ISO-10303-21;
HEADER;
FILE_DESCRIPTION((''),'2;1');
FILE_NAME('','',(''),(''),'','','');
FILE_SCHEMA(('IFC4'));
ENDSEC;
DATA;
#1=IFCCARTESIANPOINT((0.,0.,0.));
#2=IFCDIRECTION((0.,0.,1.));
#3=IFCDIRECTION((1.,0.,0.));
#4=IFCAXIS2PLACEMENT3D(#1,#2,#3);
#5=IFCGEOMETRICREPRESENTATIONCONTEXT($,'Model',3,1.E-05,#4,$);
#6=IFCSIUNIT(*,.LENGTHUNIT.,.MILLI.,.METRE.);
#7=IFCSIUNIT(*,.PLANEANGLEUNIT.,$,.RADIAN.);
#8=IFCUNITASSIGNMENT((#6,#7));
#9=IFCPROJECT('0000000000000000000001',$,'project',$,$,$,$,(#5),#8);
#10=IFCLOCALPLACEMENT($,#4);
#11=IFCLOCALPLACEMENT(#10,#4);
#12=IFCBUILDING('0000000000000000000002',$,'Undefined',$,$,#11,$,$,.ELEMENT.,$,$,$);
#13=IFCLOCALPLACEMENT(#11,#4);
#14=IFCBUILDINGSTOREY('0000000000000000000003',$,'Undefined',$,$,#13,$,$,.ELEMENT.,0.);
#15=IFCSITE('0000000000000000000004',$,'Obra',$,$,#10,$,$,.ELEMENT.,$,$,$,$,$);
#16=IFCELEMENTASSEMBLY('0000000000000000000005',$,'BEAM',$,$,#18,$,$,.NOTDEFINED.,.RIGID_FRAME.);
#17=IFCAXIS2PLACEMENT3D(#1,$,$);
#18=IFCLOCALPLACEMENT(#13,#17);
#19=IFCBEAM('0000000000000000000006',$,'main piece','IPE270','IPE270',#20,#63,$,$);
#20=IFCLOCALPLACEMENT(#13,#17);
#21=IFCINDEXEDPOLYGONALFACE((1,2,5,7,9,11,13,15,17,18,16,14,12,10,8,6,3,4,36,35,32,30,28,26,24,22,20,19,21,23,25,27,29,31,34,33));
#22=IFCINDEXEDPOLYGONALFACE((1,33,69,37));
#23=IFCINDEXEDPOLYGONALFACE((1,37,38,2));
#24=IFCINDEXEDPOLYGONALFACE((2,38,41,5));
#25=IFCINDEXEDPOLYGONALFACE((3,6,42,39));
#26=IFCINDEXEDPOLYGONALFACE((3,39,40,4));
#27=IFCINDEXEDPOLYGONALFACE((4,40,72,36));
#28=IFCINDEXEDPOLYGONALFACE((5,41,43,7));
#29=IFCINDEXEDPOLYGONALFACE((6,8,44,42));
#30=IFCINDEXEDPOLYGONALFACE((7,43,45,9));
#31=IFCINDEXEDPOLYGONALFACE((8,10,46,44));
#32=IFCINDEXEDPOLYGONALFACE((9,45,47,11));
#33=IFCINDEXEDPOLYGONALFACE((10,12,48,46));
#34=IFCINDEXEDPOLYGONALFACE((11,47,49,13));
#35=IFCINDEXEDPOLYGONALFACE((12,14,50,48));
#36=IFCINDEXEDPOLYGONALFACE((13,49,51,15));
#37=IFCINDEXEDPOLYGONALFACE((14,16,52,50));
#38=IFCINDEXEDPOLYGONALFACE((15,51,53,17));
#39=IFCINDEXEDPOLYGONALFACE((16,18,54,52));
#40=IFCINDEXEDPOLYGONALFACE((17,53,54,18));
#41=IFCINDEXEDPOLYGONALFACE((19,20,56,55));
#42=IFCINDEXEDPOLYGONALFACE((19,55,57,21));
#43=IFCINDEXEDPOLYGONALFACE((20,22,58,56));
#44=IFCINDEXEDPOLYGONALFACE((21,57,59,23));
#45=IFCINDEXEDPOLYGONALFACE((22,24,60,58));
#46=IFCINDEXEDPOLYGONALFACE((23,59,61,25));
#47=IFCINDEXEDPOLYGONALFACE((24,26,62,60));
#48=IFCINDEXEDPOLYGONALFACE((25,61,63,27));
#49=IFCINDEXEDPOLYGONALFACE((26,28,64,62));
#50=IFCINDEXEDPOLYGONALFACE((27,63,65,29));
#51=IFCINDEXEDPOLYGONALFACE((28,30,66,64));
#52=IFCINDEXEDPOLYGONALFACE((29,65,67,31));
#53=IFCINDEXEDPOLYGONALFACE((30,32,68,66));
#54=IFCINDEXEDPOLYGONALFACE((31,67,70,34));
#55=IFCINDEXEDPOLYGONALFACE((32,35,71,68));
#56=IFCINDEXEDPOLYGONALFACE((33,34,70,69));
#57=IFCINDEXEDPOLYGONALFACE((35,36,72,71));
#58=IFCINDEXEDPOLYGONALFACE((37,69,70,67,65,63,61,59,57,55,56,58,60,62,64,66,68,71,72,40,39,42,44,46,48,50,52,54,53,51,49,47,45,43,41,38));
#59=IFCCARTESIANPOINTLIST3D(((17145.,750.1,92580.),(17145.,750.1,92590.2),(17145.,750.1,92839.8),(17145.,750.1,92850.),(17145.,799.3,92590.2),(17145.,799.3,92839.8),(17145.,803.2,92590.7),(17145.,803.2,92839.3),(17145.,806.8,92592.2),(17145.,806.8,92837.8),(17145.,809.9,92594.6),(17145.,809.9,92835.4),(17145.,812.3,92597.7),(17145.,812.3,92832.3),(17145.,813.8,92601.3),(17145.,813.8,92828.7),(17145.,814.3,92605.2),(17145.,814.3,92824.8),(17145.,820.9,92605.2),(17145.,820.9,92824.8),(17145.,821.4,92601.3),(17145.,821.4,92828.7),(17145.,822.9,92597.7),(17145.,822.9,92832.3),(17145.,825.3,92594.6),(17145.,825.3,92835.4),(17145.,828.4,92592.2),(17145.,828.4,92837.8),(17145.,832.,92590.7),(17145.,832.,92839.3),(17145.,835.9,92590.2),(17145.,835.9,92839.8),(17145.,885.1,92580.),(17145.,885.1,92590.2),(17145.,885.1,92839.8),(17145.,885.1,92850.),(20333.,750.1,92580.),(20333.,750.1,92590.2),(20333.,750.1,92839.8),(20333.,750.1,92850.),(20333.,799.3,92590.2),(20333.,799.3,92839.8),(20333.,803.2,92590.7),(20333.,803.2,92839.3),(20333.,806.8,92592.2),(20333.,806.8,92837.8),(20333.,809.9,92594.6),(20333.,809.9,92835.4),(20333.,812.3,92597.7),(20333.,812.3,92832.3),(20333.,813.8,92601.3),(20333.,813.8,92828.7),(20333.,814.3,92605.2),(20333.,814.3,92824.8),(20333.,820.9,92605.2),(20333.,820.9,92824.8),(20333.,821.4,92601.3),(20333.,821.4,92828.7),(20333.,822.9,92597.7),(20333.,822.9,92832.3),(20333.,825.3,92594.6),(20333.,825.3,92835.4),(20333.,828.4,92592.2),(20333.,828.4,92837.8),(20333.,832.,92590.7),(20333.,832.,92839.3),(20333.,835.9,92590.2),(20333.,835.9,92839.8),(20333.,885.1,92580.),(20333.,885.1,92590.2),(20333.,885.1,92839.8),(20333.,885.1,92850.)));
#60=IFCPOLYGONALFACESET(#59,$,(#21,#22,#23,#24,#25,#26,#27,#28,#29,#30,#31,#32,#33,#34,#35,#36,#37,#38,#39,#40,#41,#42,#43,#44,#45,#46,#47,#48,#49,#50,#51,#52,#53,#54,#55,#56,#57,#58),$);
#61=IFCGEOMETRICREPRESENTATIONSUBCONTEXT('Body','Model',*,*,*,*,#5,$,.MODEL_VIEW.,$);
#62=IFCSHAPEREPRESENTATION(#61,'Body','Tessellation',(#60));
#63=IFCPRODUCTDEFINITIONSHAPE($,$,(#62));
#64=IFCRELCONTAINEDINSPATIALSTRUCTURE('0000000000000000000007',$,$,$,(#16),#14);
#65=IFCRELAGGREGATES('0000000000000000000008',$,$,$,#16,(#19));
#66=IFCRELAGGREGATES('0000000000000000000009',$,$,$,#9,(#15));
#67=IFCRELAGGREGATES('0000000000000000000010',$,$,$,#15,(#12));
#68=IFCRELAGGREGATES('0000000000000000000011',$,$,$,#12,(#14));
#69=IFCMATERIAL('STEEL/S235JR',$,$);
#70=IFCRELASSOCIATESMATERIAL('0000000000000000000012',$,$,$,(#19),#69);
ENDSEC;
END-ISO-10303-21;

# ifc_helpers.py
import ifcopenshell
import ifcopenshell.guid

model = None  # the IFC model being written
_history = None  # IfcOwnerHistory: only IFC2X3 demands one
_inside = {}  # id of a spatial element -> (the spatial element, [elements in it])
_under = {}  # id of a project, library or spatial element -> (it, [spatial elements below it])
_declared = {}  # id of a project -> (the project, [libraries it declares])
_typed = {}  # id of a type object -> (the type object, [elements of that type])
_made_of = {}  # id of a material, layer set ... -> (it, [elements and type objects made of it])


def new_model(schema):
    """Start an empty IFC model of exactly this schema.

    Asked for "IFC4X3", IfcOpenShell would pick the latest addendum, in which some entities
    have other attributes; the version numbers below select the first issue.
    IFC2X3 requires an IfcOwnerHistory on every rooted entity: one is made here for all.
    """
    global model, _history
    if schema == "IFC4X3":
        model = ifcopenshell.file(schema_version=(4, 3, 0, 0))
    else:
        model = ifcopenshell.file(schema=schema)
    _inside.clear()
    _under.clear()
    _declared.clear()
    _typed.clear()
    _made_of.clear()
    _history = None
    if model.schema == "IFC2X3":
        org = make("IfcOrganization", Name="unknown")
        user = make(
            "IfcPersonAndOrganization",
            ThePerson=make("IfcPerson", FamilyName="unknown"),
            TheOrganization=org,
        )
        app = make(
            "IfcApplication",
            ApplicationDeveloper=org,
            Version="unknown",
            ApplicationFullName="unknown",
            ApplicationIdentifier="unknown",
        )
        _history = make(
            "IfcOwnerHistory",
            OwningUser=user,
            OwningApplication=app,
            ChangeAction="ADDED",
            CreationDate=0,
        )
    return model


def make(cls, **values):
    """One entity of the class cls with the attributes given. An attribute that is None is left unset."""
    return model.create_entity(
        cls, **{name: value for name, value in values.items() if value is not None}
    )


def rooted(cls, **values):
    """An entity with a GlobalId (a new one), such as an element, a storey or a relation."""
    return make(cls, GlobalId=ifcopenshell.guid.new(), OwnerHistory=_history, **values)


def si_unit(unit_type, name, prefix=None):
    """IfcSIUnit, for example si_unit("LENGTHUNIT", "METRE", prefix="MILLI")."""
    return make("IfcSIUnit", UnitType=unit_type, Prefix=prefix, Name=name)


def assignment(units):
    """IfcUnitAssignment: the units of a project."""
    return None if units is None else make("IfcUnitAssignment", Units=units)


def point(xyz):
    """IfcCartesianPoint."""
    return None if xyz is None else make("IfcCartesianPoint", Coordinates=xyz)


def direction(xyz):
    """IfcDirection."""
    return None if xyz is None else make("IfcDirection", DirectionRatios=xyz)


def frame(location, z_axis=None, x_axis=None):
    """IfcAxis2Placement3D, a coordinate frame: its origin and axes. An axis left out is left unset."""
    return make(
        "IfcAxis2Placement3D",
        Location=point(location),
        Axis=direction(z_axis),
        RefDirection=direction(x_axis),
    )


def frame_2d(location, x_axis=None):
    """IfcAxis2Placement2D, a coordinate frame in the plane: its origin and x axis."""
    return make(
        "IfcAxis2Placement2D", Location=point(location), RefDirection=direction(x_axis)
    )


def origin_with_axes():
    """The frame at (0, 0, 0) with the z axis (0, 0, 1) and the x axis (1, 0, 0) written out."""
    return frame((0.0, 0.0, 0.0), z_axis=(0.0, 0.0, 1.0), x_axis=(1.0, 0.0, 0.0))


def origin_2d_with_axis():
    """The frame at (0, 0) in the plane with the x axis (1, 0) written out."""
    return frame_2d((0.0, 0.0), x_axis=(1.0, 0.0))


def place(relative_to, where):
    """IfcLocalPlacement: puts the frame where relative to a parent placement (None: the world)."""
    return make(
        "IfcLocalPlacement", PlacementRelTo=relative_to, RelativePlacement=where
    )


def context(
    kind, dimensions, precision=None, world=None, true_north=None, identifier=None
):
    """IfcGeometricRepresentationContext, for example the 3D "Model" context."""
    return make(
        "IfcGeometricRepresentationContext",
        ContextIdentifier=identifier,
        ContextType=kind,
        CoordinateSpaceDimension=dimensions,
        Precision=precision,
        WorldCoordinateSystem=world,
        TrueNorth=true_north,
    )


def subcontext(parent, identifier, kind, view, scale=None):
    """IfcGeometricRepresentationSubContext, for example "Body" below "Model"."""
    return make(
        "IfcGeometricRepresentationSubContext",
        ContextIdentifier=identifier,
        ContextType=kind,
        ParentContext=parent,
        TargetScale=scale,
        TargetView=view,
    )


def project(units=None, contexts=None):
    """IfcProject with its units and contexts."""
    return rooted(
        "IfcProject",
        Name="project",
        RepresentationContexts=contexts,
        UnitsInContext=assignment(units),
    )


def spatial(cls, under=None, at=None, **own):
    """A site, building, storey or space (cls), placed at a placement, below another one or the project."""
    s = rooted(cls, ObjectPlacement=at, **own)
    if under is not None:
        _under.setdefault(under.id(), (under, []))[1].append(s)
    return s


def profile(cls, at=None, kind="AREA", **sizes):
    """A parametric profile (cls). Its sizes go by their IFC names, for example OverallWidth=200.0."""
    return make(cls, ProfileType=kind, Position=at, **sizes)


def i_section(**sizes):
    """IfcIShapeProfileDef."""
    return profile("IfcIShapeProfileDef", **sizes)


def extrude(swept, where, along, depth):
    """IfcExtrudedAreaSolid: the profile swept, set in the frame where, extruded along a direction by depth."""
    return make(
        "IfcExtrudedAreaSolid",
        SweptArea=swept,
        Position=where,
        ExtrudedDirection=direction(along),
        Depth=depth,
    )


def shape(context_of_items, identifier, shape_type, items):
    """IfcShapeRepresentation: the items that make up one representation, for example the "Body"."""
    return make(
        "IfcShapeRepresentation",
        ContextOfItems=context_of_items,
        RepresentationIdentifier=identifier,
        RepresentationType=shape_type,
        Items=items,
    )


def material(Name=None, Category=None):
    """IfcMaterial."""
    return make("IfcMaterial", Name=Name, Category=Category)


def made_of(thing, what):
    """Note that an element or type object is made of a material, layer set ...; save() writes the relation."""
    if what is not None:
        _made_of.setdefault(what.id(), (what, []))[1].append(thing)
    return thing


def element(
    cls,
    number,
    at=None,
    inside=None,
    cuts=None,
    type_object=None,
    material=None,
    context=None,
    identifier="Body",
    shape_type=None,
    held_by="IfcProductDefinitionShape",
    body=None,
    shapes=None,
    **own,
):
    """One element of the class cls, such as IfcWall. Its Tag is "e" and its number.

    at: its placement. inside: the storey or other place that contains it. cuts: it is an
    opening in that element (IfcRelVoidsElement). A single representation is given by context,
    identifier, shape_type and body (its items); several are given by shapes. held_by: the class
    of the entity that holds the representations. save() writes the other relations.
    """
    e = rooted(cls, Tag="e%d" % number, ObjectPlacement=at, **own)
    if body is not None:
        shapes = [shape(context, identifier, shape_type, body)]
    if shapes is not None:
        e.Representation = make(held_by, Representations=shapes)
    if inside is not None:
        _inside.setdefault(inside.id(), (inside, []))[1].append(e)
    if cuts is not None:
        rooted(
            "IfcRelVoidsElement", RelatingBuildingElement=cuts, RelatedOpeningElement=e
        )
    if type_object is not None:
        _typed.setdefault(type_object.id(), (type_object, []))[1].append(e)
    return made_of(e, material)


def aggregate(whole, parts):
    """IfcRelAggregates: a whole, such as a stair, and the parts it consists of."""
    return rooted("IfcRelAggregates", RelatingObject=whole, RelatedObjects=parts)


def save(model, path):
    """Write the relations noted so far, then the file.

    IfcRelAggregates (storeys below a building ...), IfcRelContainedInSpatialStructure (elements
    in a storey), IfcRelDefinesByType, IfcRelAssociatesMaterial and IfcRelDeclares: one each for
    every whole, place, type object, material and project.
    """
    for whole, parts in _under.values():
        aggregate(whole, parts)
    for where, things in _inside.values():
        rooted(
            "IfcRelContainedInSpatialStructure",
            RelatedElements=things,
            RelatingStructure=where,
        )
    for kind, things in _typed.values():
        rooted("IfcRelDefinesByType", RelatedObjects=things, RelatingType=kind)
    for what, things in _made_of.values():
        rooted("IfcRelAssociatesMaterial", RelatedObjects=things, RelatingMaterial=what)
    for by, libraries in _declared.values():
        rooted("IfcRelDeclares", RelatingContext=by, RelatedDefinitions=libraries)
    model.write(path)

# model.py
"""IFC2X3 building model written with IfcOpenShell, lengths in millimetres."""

from ifc_helpers import new_model, si_unit, frame, origin_with_axes, origin_2d_with_axis, place, context, subcontext, project, spatial, i_section, extrude, material, element, aggregate, save


model = new_model("IFC2X3")

# Units and contexts
model_context = context("Model", 3, precision=1e-05, world=origin_with_axes())
body_context = subcontext(model_context, "Body", "Model", "MODEL_VIEW")
ifc_project = project(units=[si_unit("LENGTHUNIT", "METRE", prefix="MILLI"), si_unit("PLANEANGLEUNIT", "RADIAN")], contexts=[model_context])

# Site, building, storey
site_placement = place(None, origin_with_axes())
site = spatial("IfcSite", under=ifc_project, at=site_placement, Name="Obra", CompositionType="ELEMENT")
building_placement = place(site_placement, origin_with_axes())
building = spatial("IfcBuilding", under=site, at=building_placement, Name="Undefined", CompositionType="ELEMENT")
storey_placement = place(building_placement, origin_with_axes())
storey = spatial("IfcBuildingStorey", under=building, at=storey_placement, Name="Undefined", CompositionType="ELEMENT", Elevation=0.0)

# Shared definitions
ifc_material = material(Name="STEEL/S235JR")

# Element assembly, beam
assembly_1_placement = place(storey_placement, origin_with_axes())
assembly_1 = element("IfcElementAssembly", 1, at=assembly_1_placement, inside=storey, Name="BEAM", AssemblyPlace="NOTDEFINED", PredefinedType="RIGID_FRAME")
beam_1_placement = place(assembly_1_placement, frame((17145.0, 817.6, 92715.0), z_axis=(0.0, 0.0, 1.0), x_axis=(1.0, 0.0, 0.0)))
beam_1 = element("IfcBeam", 2, at=beam_1_placement, material=ifc_material, Name="main piece", Description="IPE270", ObjectType="IPE270", context=body_context, shape_type="SweptSolid", body=[
    extrude(i_section(OverallWidth=135.0, OverallDepth=270.0, WebThickness=6.6, FlangeThickness=10.2, FilletRadius=15.0, at=origin_2d_with_axis()), frame((3188.0, 0.0, 0.0), z_axis=(-1.0, 0.0, 0.0), x_axis=(0.0, -1.0, 0.0)), (0.0, 0.0, 1.0), 3188.0),
])
aggregate(assembly_1, [beam_1])

save(model, "model.ifc")
